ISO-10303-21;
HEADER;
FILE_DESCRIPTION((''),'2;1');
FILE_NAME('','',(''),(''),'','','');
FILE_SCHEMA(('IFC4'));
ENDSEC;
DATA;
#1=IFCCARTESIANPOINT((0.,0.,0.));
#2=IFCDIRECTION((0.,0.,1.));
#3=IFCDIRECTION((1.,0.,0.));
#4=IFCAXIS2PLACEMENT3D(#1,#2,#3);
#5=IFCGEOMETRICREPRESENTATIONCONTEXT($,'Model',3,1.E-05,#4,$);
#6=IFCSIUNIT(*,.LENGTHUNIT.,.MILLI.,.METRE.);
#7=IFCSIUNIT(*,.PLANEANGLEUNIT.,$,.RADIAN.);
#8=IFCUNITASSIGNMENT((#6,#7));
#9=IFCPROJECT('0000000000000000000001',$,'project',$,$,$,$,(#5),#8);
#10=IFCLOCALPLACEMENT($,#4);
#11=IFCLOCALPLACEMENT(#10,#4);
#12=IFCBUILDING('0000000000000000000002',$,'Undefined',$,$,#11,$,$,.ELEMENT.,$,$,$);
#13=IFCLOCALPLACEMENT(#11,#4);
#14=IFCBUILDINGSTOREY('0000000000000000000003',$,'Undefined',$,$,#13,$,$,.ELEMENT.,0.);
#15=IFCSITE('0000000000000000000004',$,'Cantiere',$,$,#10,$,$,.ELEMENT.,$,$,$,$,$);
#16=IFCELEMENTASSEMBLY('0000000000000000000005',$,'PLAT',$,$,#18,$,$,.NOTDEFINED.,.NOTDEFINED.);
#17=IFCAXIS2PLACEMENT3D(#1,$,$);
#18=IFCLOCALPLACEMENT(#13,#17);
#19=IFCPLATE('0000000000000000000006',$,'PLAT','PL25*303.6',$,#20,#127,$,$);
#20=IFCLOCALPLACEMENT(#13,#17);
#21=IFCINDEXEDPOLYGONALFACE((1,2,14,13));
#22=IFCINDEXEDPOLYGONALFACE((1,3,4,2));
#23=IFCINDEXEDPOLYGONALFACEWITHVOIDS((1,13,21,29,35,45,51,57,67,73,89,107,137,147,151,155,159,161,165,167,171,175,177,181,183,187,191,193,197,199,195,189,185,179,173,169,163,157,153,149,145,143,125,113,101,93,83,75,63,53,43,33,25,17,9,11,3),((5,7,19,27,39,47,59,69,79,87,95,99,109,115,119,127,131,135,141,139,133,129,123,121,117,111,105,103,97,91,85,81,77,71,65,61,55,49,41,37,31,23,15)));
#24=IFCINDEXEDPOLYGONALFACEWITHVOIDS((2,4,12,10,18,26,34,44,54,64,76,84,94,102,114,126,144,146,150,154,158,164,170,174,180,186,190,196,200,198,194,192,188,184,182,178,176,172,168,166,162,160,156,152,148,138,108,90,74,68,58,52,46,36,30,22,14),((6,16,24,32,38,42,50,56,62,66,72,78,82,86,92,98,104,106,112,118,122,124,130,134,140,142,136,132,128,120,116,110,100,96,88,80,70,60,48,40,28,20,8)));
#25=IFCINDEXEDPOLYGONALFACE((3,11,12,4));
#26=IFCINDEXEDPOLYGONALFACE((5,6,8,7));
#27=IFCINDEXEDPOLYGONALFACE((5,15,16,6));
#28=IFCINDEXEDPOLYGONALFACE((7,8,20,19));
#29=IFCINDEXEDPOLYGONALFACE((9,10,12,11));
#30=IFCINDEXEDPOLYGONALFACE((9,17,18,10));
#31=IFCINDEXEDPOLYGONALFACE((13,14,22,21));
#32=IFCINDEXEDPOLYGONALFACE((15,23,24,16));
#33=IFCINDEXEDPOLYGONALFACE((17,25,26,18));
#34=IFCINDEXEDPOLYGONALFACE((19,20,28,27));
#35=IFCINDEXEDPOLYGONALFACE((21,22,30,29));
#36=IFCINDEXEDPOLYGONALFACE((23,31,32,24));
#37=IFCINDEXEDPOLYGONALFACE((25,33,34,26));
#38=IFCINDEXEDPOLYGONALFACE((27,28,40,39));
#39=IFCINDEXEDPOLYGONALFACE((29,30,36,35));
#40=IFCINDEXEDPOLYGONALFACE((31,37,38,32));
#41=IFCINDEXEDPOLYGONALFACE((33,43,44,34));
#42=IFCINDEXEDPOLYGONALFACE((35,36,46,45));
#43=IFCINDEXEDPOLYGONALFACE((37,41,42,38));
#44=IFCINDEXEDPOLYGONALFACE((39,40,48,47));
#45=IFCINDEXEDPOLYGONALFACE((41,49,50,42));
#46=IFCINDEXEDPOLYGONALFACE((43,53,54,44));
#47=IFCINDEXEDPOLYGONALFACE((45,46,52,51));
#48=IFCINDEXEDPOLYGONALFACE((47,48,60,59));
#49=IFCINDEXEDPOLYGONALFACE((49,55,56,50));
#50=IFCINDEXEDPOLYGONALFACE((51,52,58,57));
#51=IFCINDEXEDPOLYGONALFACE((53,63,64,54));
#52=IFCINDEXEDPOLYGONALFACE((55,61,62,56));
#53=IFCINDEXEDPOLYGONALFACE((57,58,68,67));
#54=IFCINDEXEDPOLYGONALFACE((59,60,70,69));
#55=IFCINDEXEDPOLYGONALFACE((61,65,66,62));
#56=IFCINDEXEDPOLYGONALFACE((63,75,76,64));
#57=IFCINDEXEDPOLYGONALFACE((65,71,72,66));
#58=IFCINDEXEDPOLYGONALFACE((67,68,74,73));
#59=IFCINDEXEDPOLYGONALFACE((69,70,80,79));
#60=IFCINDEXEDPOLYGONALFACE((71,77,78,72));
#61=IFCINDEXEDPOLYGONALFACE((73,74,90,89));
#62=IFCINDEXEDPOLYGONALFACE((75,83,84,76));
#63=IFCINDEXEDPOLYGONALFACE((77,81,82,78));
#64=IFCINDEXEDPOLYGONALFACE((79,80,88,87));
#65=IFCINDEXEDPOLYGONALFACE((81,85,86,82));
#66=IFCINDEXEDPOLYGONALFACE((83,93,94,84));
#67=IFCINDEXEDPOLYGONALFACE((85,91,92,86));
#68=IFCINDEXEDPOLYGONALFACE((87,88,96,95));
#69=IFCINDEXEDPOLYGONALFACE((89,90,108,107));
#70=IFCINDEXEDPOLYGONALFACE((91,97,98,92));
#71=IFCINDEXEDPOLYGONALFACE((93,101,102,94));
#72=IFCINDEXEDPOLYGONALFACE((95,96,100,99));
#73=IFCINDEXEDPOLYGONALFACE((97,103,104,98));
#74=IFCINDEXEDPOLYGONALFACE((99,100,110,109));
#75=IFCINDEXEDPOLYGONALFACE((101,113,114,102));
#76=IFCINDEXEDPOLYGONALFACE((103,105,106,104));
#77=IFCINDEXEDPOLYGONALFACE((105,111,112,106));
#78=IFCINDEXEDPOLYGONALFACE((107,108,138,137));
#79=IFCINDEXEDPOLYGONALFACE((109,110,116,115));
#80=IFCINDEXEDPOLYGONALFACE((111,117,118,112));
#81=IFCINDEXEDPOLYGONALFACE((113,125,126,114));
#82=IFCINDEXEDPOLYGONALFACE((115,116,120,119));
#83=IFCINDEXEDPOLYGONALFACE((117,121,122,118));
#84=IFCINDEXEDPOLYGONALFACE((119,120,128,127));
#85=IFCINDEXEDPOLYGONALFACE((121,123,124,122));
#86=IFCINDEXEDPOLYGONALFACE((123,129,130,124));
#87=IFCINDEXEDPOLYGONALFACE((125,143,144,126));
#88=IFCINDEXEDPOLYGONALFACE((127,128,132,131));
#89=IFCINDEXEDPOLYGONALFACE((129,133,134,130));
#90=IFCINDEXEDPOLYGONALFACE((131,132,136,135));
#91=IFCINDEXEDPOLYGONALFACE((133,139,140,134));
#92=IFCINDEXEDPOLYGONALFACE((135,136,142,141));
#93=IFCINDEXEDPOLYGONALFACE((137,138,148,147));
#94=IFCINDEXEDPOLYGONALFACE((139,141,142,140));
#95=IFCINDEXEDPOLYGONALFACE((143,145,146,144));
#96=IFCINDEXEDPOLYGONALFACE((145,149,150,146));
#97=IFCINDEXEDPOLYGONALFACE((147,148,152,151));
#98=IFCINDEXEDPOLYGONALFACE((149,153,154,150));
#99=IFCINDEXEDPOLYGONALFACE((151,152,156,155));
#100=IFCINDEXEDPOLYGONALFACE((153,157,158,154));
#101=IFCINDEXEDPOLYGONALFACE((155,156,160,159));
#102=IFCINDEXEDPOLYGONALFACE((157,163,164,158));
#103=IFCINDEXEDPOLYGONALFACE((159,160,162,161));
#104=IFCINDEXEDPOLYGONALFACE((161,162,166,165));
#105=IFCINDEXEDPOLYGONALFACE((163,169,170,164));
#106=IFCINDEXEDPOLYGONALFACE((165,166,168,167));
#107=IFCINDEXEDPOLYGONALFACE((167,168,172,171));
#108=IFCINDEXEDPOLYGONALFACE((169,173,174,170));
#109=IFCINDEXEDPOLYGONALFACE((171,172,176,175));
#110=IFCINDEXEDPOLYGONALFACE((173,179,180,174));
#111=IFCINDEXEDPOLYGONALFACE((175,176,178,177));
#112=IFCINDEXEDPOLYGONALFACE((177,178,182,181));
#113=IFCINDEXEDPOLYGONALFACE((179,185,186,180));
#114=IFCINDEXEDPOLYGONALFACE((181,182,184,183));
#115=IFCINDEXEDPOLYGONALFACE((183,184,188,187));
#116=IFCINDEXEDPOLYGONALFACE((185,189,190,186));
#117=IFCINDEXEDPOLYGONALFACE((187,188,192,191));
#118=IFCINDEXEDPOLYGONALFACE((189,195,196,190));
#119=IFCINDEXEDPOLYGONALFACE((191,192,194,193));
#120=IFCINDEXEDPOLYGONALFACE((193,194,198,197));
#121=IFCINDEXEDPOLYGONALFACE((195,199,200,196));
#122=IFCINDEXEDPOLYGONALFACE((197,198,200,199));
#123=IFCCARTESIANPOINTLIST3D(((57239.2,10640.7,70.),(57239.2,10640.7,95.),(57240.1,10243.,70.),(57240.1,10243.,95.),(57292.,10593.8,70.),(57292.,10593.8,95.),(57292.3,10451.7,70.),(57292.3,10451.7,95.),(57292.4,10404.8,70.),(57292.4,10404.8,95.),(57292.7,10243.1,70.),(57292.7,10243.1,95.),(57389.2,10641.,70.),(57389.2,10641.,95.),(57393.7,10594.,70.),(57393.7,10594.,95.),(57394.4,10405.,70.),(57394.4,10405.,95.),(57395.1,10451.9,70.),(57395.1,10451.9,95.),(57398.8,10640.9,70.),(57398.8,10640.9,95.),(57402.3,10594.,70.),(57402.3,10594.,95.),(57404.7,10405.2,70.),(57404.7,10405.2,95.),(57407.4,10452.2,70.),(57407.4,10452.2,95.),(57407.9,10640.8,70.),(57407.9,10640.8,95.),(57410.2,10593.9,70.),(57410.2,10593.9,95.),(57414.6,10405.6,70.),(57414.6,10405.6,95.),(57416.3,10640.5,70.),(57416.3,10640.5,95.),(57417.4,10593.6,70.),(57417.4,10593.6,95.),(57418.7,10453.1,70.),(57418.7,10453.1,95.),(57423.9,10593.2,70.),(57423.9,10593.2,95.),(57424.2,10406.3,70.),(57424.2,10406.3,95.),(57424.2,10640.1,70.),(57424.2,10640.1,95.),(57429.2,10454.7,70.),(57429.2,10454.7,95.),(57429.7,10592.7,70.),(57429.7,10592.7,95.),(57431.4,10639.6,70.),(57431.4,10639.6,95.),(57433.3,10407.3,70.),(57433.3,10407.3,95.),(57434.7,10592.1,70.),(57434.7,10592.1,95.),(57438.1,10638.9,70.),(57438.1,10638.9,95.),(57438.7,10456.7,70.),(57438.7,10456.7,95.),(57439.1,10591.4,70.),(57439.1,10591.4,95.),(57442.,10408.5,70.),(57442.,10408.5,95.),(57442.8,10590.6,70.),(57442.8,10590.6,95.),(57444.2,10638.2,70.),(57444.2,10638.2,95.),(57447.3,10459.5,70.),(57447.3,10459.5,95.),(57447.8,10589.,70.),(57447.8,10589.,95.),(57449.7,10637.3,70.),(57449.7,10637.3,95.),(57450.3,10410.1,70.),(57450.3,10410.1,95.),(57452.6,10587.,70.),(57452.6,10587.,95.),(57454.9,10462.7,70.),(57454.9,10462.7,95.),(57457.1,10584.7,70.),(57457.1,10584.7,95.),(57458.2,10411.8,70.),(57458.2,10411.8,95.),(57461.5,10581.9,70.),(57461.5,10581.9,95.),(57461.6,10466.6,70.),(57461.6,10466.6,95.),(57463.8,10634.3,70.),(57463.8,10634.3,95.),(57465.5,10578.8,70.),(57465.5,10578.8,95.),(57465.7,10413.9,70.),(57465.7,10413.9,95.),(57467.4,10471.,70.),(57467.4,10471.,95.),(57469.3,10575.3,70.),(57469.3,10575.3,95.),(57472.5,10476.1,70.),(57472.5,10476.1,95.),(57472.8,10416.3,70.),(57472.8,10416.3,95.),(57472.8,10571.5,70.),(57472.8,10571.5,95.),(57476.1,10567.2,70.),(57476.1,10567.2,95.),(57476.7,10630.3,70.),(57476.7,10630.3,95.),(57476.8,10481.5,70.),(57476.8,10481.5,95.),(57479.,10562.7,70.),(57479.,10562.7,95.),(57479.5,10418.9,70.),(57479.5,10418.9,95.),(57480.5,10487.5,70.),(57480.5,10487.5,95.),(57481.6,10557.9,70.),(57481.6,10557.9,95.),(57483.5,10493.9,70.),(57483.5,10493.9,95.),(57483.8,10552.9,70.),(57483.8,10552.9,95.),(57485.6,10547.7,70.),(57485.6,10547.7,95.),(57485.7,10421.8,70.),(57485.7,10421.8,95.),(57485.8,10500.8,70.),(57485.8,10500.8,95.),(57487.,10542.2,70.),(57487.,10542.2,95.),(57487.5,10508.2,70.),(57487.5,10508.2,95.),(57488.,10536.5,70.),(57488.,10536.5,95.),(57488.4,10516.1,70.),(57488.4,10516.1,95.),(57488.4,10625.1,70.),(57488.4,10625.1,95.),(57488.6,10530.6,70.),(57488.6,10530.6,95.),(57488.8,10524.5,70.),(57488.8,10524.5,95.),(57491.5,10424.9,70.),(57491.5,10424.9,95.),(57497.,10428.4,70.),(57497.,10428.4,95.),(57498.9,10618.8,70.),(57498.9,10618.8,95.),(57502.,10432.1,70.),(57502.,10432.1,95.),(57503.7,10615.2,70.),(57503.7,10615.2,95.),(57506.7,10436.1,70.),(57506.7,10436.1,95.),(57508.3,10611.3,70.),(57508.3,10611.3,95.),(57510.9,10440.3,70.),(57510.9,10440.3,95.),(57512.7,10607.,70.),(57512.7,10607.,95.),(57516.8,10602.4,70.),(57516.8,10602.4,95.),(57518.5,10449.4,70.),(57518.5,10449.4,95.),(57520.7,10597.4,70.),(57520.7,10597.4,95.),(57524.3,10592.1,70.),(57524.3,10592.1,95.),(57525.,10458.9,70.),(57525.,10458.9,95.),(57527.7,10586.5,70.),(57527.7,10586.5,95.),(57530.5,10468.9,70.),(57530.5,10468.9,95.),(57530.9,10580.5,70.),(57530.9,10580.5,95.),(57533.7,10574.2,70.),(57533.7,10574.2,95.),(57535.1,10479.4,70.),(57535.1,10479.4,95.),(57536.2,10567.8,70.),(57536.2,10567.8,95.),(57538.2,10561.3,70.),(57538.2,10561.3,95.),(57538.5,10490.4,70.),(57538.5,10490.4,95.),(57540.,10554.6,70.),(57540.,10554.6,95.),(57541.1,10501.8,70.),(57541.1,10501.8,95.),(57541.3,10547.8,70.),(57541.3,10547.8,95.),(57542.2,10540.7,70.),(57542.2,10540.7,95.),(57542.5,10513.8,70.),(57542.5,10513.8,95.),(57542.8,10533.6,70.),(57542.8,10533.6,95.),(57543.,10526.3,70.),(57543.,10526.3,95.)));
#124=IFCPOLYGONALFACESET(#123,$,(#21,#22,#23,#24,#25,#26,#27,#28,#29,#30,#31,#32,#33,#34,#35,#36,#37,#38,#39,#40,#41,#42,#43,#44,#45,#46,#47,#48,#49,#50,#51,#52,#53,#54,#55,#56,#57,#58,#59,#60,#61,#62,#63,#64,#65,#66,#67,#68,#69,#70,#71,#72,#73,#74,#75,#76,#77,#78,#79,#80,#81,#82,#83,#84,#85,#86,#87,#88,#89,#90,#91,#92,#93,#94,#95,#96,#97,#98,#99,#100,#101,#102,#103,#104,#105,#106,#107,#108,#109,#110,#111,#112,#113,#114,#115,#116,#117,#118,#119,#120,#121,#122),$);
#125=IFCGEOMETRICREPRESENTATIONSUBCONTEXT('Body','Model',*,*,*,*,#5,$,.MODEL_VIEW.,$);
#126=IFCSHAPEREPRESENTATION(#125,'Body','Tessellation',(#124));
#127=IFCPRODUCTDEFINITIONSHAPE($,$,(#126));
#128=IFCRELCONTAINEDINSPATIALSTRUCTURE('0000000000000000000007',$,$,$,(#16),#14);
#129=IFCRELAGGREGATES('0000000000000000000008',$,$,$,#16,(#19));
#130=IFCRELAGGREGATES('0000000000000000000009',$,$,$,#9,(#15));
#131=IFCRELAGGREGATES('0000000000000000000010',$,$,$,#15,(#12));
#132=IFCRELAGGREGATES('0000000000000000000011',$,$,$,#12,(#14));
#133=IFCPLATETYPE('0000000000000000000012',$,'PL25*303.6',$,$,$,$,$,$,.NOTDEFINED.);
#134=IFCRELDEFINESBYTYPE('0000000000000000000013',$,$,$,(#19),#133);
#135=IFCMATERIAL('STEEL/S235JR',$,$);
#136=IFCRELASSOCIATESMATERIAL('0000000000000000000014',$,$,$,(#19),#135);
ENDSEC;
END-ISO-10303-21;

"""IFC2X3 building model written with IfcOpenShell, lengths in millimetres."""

from ifc_helpers import new_model, si_unit, frame, origin_with_axes, place, context, subcontext, project, spatial, polyline, outline, extrude, boolean, material, type_object, element, aggregate, save


model = new_model("IFC2X3")

# Units and contexts
model_context = context("Model", 3, precision=1e-05, world=origin_with_axes())
body_context = subcontext(model_context, "Body", "Model", "MODEL_VIEW")
ifc_project = project(units=[si_unit("LENGTHUNIT", "METRE", prefix="MILLI"), si_unit("PLANEANGLEUNIT", "RADIAN")], contexts=[model_context])

# Site, building, storey
site_placement = place(None, origin_with_axes())
site = spatial("IfcSite", under=ifc_project, at=site_placement, Name="Cantiere", CompositionType="ELEMENT")
building_placement = place(site_placement, origin_with_axes())
building = spatial("IfcBuilding", under=site, at=building_placement, Name="Undefined", CompositionType="ELEMENT")
storey_placement = place(building_placement, origin_with_axes())
storey = spatial("IfcBuildingStorey", under=building, at=storey_placement, Name="Undefined", CompositionType="ELEMENT", Elevation=0.0)

# Shared definitions
ifc_material_1 = material(Name="STEEL/S235JR")

# Element assembly, plate
assembly_1_placement = place(storey_placement, origin_with_axes())
assembly_1 = element("IfcElementAssembly", 1, at=assembly_1_placement, inside=storey, Name="PLAT", AssemblyPlace="NOTDEFINED", PredefinedType="NOTDEFINED")
plate_type_1 = type_object("IfcPlateType", Name="PL25*303.6", PredefinedType="NOTDEFINED")
plate_1_placement = place(assembly_1_placement, frame((57240.1, 10243.0, 82.5), z_axis=(0.0, 0.000001, -1.0), x_axis=(-0.00212, 0.999998, 0.0)))
plate_1 = element("IfcPlate", 2, at=plate_1_placement, type_object=plate_type_1, material=ifc_material_1, Name="PLAT", Description="PL25*303.6", context=body_context, shape_type="CSG", body=[
    boolean("DIFFERENCE", extrude(outline(polyline([(0.0, 0.0), (397.7, 0.0), (397.7, 150.0), (397.7, 159.6), (397.5, 168.7), (397.2, 177.1), (396.8, 185.0), (396.2, 192.2), (395.6, 198.9), (394.8, 205.0), (393.9, 210.5), (390.9, 224.6), (386.8, 237.5), (381.6, 249.1), (375.3, 259.6), (371.7, 264.5), (367.8, 269.0), (363.5, 273.4), (358.9, 277.5), (353.9, 281.4), (348.6, 285.0), (342.9, 288.4), (336.9, 291.5), (330.7, 294.4), (324.3, 296.8), (317.7, 298.9), (311.0, 300.6), (304.2, 301.9), (297.1, 302.8), (290.0, 303.4), (282.7, 303.6), (270.2, 303.1), (258.3, 301.6), (246.8, 299.0), (235.8, 295.5), (225.3, 291.0), (215.3, 285.4), (205.8, 278.9), (196.8, 271.3), (192.5, 267.0), (188.5, 262.4), (184.8, 257.3), (181.5, 251.9), (178.3, 246.0), (175.4, 239.8), (172.8, 233.1), (170.4, 226.0), (168.4, 218.5), (166.6, 210.6), (165.1, 202.3), (163.9, 193.6), (162.9, 184.5), (162.2, 174.9), (161.8, 165.0), (161.7, 154.7), (161.7, 52.7), (0.0, 52.7), (0.0, 0.0)])), frame((0.0, 0.0, -12.5), z_axis=(0.0, 0.0, 1.0), x_axis=(1.0, 0.0, 0.0)), (0.0, 0.0, 1.0), 25.0), extrude(outline(polyline([(0.0, 0.0), (102.8, 0.0), (115.1, 0.3), (126.5, 1.2), (136.9, 2.7), (146.4, 4.8), (155.0, 7.5), (162.7, 10.7), (169.4, 14.6), (175.2, 19.0), (180.3, 24.0), (184.6, 29.5), (188.3, 35.4), (191.3, 41.9), (193.7, 48.8), (195.3, 56.2), (196.3, 64.1), (196.7, 72.5), (196.5, 78.6), (195.9, 84.5), (194.9, 90.2), (193.5, 95.6), (191.8, 100.8), (189.5, 105.8), (187.0, 110.6), (184.0, 115.2), (180.8, 119.4), (177.3, 123.3), (173.5, 126.8), (169.5, 129.9), (165.2, 132.7), (160.6, 135.0), (155.9, 137.0), (150.8, 138.6), (147.2, 139.5), (142.8, 140.2), (137.7, 140.8), (131.9, 141.3), (125.4, 141.7), (118.2, 142.0), (110.3, 142.1), (101.7, 142.2), (0.0, 142.2), (0.0, 0.0)])), frame((208.6, 52.7, 12.5), z_axis=(0.0, 0.000001, -1.0), x_axis=(0.0, 1.0, 0.0)), (0.0, 0.0, 1.0), 25.0)),
])
aggregate(assembly_1, [plate_1])

save(model, "model.ifc")
